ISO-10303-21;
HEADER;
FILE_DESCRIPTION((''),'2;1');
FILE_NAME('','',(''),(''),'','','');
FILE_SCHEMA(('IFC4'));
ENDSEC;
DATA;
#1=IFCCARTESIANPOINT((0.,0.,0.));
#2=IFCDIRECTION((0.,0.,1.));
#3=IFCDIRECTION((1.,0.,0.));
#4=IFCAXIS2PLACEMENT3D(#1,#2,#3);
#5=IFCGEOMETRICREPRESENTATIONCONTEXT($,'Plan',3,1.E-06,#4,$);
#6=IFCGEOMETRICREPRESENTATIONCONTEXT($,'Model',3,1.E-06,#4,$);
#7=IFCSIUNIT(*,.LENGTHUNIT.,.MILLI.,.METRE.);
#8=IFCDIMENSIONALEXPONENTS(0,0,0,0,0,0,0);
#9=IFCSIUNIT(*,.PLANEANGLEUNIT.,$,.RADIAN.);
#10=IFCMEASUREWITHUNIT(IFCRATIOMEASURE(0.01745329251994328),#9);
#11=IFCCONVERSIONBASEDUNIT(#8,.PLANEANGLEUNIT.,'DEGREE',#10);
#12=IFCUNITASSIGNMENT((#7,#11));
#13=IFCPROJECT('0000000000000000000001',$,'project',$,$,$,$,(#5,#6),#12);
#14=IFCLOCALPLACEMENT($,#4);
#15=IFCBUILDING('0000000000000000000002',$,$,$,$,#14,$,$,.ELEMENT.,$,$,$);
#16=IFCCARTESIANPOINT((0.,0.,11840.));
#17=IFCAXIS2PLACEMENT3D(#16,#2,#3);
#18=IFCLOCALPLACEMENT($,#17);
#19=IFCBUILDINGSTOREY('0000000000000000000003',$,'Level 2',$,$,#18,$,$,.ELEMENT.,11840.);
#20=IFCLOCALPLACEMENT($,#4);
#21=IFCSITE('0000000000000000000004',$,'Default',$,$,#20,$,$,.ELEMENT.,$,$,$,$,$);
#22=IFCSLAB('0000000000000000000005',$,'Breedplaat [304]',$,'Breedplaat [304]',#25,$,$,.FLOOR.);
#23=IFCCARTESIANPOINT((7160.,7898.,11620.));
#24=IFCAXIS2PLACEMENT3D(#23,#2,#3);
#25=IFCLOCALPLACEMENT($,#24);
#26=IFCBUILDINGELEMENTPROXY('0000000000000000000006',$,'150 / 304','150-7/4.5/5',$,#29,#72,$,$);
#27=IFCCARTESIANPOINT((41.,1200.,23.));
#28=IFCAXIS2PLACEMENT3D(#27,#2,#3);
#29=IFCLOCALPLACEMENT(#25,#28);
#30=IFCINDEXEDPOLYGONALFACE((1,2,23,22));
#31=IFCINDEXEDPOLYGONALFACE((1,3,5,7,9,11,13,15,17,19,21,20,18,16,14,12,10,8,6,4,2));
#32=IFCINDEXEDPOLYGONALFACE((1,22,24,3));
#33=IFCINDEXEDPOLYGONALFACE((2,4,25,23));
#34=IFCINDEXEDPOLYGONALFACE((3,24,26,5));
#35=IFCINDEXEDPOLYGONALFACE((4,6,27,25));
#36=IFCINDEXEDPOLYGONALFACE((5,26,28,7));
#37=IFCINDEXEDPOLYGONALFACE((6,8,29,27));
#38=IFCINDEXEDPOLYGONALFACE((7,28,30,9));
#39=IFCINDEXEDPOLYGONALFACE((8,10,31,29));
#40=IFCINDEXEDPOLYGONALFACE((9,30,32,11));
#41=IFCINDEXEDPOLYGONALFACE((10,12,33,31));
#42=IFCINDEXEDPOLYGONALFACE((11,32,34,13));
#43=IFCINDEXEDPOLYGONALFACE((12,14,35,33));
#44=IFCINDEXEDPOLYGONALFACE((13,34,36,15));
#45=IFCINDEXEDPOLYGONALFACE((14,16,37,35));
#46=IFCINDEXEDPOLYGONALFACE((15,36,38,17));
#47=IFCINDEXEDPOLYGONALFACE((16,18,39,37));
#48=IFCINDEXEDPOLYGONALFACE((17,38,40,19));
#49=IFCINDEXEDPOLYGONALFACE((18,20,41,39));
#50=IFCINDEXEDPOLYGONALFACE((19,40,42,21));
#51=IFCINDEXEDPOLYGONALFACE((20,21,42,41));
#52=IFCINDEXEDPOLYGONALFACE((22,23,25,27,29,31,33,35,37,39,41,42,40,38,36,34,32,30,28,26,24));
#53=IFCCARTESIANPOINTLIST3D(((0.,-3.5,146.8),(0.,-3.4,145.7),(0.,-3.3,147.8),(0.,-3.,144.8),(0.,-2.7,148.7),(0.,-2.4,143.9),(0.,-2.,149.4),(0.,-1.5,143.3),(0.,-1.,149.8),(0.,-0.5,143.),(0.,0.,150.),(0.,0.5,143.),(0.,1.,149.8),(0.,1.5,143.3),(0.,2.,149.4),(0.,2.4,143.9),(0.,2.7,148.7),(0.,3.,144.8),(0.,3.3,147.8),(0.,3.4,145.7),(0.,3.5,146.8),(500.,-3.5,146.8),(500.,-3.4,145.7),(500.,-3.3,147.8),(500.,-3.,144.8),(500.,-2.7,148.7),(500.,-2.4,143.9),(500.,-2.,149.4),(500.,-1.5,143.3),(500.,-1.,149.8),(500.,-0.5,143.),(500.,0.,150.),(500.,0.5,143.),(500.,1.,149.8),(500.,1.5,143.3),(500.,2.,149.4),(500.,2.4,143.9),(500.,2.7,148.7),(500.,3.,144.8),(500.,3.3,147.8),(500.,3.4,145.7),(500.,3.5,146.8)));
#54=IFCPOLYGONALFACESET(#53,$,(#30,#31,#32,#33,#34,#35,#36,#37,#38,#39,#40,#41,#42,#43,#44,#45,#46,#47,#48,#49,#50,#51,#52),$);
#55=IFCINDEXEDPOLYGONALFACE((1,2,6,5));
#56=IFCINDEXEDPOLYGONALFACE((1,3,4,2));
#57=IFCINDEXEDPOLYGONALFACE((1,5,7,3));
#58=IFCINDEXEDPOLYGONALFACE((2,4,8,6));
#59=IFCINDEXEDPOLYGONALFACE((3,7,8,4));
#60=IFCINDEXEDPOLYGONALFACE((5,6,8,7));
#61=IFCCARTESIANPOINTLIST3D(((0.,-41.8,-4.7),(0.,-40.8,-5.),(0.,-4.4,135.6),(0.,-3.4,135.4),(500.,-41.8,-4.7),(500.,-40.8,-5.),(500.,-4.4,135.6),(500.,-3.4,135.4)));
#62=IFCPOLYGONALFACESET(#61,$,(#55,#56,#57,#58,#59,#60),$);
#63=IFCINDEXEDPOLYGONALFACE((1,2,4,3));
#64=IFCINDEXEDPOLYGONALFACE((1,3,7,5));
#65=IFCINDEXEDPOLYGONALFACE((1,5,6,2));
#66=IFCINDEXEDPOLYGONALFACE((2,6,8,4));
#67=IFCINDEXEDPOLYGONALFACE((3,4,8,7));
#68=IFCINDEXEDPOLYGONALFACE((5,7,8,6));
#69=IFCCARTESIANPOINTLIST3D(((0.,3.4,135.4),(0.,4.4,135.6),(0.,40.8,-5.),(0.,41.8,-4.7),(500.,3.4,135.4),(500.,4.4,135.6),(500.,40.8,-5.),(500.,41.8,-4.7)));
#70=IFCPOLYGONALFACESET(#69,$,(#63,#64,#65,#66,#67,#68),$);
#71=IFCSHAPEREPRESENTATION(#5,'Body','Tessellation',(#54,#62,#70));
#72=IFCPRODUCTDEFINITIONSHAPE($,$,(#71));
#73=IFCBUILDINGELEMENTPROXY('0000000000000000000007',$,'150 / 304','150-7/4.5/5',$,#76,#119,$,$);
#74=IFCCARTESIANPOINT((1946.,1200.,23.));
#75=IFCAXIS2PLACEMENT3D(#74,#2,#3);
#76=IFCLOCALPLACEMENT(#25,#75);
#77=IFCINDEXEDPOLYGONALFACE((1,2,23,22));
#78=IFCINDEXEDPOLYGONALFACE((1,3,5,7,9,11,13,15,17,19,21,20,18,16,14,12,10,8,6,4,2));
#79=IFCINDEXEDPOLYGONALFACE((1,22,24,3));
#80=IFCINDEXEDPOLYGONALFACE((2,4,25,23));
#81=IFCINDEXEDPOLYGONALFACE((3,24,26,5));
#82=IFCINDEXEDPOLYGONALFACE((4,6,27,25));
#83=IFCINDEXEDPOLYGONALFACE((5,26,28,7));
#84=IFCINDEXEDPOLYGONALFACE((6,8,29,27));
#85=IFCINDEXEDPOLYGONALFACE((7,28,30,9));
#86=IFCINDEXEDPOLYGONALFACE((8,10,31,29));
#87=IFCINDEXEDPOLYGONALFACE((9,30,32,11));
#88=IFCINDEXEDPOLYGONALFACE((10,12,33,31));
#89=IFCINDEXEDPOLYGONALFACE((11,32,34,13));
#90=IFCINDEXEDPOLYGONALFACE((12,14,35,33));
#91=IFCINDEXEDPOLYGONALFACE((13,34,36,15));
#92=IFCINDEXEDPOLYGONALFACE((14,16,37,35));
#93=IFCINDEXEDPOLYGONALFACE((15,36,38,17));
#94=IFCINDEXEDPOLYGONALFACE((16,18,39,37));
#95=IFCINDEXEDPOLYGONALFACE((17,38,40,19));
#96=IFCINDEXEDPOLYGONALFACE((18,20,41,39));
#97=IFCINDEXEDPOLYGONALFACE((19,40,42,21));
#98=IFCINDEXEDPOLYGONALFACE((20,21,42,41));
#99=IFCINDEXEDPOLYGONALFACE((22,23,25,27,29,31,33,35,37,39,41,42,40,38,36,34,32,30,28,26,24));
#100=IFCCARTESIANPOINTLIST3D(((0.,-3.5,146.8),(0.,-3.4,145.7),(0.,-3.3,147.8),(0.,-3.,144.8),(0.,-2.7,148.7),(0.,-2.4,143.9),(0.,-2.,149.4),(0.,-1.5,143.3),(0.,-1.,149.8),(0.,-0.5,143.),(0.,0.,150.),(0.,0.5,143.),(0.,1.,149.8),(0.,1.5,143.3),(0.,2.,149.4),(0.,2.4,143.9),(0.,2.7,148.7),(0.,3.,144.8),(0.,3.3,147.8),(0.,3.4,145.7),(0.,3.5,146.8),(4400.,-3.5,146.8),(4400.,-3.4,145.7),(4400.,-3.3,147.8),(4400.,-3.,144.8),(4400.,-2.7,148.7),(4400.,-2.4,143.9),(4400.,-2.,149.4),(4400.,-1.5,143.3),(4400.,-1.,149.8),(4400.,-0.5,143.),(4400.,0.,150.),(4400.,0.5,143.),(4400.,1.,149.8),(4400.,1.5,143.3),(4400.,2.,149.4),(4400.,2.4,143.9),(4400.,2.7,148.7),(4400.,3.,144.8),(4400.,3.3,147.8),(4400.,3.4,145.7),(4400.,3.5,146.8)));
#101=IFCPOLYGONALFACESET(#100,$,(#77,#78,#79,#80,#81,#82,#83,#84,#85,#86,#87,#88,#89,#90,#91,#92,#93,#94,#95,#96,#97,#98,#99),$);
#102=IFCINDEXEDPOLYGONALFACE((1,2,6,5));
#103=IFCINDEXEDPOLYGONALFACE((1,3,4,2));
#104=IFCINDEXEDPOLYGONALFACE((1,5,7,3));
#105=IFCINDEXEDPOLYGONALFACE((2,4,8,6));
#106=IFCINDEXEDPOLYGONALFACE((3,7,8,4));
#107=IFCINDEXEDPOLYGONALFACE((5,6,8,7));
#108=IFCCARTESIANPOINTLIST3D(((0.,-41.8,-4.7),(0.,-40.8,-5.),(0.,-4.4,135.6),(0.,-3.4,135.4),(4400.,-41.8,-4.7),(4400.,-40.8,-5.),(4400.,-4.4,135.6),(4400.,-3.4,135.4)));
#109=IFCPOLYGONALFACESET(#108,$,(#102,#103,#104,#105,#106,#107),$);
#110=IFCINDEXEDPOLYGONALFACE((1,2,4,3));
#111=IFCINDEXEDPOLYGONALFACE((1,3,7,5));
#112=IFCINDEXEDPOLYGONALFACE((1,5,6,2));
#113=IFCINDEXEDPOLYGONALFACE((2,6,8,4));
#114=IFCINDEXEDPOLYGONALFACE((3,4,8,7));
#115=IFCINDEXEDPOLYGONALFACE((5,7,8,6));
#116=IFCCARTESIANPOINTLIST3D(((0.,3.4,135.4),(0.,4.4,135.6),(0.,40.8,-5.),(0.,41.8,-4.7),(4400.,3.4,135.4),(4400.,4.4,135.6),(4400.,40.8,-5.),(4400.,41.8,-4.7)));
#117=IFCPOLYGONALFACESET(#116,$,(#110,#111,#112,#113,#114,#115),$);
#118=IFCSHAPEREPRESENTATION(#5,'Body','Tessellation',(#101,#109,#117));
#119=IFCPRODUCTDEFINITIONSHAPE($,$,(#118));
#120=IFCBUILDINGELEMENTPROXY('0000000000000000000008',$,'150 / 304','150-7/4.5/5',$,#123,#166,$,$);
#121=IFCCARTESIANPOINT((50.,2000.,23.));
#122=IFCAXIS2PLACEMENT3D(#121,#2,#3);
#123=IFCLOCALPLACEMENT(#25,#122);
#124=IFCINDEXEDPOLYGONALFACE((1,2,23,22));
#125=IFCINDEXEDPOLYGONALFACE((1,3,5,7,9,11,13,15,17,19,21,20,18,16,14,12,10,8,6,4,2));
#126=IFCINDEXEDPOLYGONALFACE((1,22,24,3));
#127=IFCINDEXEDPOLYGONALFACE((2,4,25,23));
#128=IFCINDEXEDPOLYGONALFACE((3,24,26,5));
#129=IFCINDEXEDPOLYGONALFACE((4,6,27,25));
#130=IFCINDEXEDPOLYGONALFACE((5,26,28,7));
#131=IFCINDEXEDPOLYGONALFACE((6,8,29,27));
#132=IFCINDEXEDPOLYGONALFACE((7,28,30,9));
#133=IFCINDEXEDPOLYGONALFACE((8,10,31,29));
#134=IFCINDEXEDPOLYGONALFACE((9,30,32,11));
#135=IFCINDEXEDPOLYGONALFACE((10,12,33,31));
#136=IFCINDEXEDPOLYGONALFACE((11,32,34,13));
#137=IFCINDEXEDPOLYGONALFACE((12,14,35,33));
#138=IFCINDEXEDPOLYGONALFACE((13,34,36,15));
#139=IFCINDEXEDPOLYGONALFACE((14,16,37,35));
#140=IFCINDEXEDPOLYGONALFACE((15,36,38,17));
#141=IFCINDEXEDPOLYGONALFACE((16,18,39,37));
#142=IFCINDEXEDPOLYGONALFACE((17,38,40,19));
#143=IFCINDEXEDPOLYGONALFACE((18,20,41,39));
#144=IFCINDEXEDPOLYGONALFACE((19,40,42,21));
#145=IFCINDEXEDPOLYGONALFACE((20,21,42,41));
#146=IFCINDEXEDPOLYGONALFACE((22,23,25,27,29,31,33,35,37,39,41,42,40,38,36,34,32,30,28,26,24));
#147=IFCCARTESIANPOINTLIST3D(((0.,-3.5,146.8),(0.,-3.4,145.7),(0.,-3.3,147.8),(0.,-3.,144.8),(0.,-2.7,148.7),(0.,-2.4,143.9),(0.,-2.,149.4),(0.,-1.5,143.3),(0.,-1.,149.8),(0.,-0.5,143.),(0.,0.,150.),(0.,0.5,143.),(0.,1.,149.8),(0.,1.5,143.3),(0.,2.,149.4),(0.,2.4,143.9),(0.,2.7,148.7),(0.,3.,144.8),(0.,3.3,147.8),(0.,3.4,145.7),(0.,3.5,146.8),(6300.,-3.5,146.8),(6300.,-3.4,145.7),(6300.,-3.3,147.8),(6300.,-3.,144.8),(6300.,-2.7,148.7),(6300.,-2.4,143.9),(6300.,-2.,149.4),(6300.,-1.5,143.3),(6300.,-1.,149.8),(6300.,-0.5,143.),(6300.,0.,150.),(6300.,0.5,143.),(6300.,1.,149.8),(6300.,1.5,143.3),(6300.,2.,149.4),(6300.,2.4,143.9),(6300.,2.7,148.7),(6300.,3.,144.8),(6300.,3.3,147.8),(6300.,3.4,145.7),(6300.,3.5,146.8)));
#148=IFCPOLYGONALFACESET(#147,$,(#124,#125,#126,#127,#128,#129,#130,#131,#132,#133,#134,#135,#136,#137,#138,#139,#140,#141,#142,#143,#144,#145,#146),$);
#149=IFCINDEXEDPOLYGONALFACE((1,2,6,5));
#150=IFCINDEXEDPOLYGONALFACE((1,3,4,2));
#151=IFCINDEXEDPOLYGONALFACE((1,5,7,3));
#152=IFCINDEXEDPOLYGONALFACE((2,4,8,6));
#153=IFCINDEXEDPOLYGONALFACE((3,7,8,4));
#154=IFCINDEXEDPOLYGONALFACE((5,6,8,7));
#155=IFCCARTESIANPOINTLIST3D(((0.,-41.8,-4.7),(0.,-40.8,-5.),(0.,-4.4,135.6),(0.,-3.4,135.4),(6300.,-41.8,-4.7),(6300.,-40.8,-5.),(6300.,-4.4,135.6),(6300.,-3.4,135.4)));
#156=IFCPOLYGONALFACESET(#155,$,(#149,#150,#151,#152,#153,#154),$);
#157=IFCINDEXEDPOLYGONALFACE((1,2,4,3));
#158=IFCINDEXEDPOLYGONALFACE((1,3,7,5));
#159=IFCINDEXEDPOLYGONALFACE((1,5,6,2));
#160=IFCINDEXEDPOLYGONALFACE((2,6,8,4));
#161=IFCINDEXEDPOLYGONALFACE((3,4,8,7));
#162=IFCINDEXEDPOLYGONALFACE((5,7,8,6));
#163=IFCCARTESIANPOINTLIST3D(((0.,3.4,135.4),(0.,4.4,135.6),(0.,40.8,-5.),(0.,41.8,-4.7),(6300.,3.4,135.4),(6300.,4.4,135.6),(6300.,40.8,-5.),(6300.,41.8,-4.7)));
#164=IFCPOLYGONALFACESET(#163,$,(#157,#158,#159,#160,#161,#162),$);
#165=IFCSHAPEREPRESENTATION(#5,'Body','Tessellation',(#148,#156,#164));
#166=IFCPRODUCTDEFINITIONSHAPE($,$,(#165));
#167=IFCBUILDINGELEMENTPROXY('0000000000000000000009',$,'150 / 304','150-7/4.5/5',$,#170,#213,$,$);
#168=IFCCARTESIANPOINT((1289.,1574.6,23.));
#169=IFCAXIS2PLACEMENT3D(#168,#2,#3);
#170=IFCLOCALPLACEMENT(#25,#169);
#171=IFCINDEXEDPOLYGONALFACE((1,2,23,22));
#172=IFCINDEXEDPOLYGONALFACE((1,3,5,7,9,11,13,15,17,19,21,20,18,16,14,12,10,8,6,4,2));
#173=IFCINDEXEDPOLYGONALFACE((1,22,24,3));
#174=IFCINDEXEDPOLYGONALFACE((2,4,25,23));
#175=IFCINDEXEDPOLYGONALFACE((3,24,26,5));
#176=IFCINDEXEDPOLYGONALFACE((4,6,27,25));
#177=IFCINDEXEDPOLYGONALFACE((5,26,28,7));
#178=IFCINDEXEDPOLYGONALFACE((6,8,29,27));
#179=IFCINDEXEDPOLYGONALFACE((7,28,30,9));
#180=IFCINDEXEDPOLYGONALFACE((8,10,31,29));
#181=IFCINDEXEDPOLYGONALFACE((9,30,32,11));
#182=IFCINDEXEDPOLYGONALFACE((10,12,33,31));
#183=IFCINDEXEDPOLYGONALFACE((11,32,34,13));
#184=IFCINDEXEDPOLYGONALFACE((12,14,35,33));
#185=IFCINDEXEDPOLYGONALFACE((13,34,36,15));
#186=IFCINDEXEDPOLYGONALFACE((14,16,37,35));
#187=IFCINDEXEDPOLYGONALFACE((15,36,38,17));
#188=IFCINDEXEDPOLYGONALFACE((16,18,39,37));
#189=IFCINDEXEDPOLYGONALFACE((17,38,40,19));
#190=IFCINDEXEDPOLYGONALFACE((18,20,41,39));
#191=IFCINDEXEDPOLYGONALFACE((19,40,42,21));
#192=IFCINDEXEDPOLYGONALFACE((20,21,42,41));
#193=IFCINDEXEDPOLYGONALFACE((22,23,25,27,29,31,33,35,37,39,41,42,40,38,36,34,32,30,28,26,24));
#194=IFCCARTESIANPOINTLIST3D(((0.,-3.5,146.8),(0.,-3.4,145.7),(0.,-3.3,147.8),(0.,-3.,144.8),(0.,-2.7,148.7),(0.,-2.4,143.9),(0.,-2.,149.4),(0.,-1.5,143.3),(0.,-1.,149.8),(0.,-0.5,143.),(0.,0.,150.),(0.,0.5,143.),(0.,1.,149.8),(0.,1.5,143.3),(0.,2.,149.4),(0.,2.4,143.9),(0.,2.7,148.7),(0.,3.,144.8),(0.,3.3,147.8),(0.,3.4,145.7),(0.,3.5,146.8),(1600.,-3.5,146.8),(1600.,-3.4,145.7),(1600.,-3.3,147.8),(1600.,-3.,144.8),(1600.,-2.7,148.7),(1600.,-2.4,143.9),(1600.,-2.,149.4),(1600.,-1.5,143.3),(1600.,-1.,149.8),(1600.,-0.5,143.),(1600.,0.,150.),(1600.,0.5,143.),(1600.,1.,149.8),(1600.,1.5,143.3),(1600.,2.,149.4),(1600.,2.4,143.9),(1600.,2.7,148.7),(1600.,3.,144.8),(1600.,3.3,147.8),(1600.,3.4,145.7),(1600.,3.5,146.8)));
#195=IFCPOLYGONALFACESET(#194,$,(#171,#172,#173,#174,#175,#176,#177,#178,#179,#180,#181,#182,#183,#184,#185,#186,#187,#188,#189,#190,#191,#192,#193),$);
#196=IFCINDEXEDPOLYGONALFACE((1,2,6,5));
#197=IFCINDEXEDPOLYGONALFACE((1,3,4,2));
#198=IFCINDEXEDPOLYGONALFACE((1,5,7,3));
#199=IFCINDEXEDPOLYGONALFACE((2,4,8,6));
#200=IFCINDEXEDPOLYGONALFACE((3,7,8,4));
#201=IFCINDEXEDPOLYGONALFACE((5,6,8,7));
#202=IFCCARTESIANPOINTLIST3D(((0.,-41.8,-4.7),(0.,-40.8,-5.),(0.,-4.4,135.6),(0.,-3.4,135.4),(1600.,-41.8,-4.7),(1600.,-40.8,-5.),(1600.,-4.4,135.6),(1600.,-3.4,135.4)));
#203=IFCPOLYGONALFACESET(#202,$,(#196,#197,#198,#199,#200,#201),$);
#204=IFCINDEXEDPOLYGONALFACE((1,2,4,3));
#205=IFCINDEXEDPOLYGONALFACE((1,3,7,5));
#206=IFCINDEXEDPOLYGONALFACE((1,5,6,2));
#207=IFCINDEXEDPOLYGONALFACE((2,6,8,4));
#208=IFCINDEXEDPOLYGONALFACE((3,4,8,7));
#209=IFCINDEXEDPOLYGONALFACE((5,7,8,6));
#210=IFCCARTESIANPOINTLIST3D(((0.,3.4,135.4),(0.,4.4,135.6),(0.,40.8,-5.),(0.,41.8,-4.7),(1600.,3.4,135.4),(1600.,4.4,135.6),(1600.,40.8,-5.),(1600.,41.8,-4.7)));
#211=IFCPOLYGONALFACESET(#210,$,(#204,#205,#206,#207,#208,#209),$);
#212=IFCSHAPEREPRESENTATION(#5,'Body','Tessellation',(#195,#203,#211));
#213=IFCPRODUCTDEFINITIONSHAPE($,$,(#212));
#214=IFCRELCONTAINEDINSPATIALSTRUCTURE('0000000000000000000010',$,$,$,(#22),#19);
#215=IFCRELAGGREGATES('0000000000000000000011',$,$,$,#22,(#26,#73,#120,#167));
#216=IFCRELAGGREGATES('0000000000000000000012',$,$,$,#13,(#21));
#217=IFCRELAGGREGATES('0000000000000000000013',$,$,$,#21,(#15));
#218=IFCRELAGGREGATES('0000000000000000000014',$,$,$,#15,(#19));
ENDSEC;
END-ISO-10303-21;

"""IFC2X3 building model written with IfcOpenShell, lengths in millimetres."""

from ifc_helpers import new_model, entity, si_unit, converted_unit, frame, origin_with_axes, origin_2d_with_axis, place, context, project, spatial, rectangle, circle, extrude, element, aggregate, save


model = new_model("IFC2X3")

# Units and contexts
plan_context = context("Plan", 3, precision=1e-06, world=origin_with_axes())
model_context = context("Model", 3, precision=1e-06, world=origin_with_axes())
ifc_project = project(units=[si_unit("LENGTHUNIT", "METRE", prefix="MILLI"), converted_unit("PLANEANGLEUNIT", "DEGREE", entity("IfcRatioMeasure", 0.01745329251994328), si_unit("PLANEANGLEUNIT", "RADIAN"), dimensions=[0, 0, 0, 0, 0, 0, 0])], contexts=[plan_context, model_context])

# Site, building, storey
site_placement = place(None, origin_with_axes())
site = spatial("IfcSite", under=ifc_project, at=site_placement, Name="Default", CompositionType="ELEMENT")
building_placement = place(None, origin_with_axes())
building = spatial("IfcBuilding", under=site, at=building_placement, CompositionType="ELEMENT")
storey_placement = place(None, frame((0.0, 0.0, 11840.0), z_axis=(0.0, 0.0, 1.0), x_axis=(1.0, 0.0, 0.0)))
storey = spatial("IfcBuildingStorey", under=building, at=storey_placement, Name="Level 2", CompositionType="ELEMENT", Elevation=11840.0)

# Slab, building element proxies
slab_1_placement = place(None, frame((7160.0, 7898.0, 11620.0), z_axis=(0.0, 0.0, 1.0), x_axis=(1.0, 0.0, 0.0)))
slab_1 = element("IfcSlab", 1, at=slab_1_placement, inside=storey, Name="Breedplaat [304]", ObjectType="Breedplaat [304]", PredefinedType="FLOOR")
proxy_1_placement = place(slab_1_placement, frame((41.0, 1200.0, 23.0), z_axis=(0.0, 0.0, 1.0), x_axis=(1.0, 0.0, 0.0)))
proxy_1 = element("IfcBuildingElementProxy", 2, at=proxy_1_placement, Name="150 / 304", Description="150-7/4.5/5", context=plan_context, shape_type="SweptSolid", body=[
    extrude(circle(Radius=3.5, at=origin_2d_with_axis()), frame((0.0, 0.0, 146.5), z_axis=(1.0, 0.0, 0.0), x_axis=(0.0, 0.0, 1.0)), (0.0, 0.0, 1.0), 500.0),
    extrude(rectangle(XDim=145.2, YDim=1.0, at=origin_2d_with_axis()), frame((0.0, -22.6, 65.3), z_axis=(1.0, 0.0, 0.0), x_axis=(0.0, 0.257663, 0.966235)), (0.0, 0.0, 1.0), 500.0),
    extrude(rectangle(XDim=145.2, YDim=1.0, at=origin_2d_with_axis()), frame((0.0, 22.6, 65.3), z_axis=(1.0, 0.0, 0.0), x_axis=(0.0, -0.257663, 0.966235)), (0.0, 0.0, 1.0), 500.0),
])
proxy_2_placement = place(slab_1_placement, frame((1946.0, 1200.0, 23.0), z_axis=(0.0, 0.0, 1.0), x_axis=(1.0, 0.0, 0.0)))
proxy_2 = element("IfcBuildingElementProxy", 3, at=proxy_2_placement, Name="150 / 304", Description="150-7/4.5/5", context=plan_context, shape_type="SweptSolid", body=[
    extrude(circle(Radius=3.5, at=origin_2d_with_axis()), frame((0.0, 0.0, 146.5), z_axis=(1.0, 0.0, 0.0), x_axis=(0.0, 0.0, 1.0)), (0.0, 0.0, 1.0), 4400.0),
    extrude(rectangle(XDim=145.2, YDim=1.0, at=origin_2d_with_axis()), frame((0.0, -22.6, 65.3), z_axis=(1.0, 0.0, 0.0), x_axis=(0.0, 0.257663, 0.966235)), (0.0, 0.0, 1.0), 4400.0),
    extrude(rectangle(XDim=145.2, YDim=1.0, at=origin_2d_with_axis()), frame((0.0, 22.6, 65.3), z_axis=(1.0, 0.0, 0.0), x_axis=(0.0, -0.257663, 0.966235)), (0.0, 0.0, 1.0), 4400.0),
])
proxy_3_placement = place(slab_1_placement, frame((50.0, 2000.0, 23.0), z_axis=(0.0, 0.0, 1.0), x_axis=(1.0, 0.0, 0.0)))
proxy_3 = element("IfcBuildingElementProxy", 4, at=proxy_3_placement, Name="150 / 304", Description="150-7/4.5/5", context=plan_context, shape_type="SweptSolid", body=[
    extrude(circle(Radius=3.5, at=origin_2d_with_axis()), frame((0.0, 0.0, 146.5), z_axis=(1.0, 0.0, 0.0), x_axis=(0.0, 0.0, 1.0)), (0.0, 0.0, 1.0), 6300.0),
    extrude(rectangle(XDim=145.2, YDim=1.0, at=origin_2d_with_axis()), frame((0.0, -22.6, 65.3), z_axis=(1.0, 0.0, 0.0), x_axis=(0.0, 0.257663, 0.966235)), (0.0, 0.0, 1.0), 6300.0),
    extrude(rectangle(XDim=145.2, YDim=1.0, at=origin_2d_with_axis()), frame((0.0, 22.6, 65.3), z_axis=(1.0, 0.0, 0.0), x_axis=(0.0, -0.257663, 0.966235)), (0.0, 0.0, 1.0), 6300.0),
])
proxy_4_placement = place(slab_1_placement, frame((1289.0, 1574.6, 23.0), z_axis=(0.0, 0.0, 1.0), x_axis=(1.0, 0.0, 0.0)))
proxy_4 = element("IfcBuildingElementProxy", 5, at=proxy_4_placement, Name="150 / 304", Description="150-7/4.5/5", context=plan_context, shape_type="SweptSolid", body=[
    extrude(circle(Radius=3.5, at=origin_2d_with_axis()), frame((0.0, 0.0, 146.5), z_axis=(1.0, 0.0, 0.0), x_axis=(0.0, 0.0, 1.0)), (0.0, 0.0, 1.0), 1600.0),
    extrude(rectangle(XDim=145.2, YDim=1.0, at=origin_2d_with_axis()), frame((0.0, -22.6, 65.3), z_axis=(1.0, 0.0, 0.0), x_axis=(0.0, 0.257663, 0.966235)), (0.0, 0.0, 1.0), 1600.0),
    extrude(rectangle(XDim=145.2, YDim=1.0, at=origin_2d_with_axis()), frame((0.0, 22.6, 65.3), z_axis=(1.0, 0.0, 0.0), x_axis=(0.0, -0.257663, 0.966235)), (0.0, 0.0, 1.0), 1600.0),
])
aggregate(slab_1, [proxy_1, proxy_2, proxy_3, proxy_4])

save(model, "model.ifc")
